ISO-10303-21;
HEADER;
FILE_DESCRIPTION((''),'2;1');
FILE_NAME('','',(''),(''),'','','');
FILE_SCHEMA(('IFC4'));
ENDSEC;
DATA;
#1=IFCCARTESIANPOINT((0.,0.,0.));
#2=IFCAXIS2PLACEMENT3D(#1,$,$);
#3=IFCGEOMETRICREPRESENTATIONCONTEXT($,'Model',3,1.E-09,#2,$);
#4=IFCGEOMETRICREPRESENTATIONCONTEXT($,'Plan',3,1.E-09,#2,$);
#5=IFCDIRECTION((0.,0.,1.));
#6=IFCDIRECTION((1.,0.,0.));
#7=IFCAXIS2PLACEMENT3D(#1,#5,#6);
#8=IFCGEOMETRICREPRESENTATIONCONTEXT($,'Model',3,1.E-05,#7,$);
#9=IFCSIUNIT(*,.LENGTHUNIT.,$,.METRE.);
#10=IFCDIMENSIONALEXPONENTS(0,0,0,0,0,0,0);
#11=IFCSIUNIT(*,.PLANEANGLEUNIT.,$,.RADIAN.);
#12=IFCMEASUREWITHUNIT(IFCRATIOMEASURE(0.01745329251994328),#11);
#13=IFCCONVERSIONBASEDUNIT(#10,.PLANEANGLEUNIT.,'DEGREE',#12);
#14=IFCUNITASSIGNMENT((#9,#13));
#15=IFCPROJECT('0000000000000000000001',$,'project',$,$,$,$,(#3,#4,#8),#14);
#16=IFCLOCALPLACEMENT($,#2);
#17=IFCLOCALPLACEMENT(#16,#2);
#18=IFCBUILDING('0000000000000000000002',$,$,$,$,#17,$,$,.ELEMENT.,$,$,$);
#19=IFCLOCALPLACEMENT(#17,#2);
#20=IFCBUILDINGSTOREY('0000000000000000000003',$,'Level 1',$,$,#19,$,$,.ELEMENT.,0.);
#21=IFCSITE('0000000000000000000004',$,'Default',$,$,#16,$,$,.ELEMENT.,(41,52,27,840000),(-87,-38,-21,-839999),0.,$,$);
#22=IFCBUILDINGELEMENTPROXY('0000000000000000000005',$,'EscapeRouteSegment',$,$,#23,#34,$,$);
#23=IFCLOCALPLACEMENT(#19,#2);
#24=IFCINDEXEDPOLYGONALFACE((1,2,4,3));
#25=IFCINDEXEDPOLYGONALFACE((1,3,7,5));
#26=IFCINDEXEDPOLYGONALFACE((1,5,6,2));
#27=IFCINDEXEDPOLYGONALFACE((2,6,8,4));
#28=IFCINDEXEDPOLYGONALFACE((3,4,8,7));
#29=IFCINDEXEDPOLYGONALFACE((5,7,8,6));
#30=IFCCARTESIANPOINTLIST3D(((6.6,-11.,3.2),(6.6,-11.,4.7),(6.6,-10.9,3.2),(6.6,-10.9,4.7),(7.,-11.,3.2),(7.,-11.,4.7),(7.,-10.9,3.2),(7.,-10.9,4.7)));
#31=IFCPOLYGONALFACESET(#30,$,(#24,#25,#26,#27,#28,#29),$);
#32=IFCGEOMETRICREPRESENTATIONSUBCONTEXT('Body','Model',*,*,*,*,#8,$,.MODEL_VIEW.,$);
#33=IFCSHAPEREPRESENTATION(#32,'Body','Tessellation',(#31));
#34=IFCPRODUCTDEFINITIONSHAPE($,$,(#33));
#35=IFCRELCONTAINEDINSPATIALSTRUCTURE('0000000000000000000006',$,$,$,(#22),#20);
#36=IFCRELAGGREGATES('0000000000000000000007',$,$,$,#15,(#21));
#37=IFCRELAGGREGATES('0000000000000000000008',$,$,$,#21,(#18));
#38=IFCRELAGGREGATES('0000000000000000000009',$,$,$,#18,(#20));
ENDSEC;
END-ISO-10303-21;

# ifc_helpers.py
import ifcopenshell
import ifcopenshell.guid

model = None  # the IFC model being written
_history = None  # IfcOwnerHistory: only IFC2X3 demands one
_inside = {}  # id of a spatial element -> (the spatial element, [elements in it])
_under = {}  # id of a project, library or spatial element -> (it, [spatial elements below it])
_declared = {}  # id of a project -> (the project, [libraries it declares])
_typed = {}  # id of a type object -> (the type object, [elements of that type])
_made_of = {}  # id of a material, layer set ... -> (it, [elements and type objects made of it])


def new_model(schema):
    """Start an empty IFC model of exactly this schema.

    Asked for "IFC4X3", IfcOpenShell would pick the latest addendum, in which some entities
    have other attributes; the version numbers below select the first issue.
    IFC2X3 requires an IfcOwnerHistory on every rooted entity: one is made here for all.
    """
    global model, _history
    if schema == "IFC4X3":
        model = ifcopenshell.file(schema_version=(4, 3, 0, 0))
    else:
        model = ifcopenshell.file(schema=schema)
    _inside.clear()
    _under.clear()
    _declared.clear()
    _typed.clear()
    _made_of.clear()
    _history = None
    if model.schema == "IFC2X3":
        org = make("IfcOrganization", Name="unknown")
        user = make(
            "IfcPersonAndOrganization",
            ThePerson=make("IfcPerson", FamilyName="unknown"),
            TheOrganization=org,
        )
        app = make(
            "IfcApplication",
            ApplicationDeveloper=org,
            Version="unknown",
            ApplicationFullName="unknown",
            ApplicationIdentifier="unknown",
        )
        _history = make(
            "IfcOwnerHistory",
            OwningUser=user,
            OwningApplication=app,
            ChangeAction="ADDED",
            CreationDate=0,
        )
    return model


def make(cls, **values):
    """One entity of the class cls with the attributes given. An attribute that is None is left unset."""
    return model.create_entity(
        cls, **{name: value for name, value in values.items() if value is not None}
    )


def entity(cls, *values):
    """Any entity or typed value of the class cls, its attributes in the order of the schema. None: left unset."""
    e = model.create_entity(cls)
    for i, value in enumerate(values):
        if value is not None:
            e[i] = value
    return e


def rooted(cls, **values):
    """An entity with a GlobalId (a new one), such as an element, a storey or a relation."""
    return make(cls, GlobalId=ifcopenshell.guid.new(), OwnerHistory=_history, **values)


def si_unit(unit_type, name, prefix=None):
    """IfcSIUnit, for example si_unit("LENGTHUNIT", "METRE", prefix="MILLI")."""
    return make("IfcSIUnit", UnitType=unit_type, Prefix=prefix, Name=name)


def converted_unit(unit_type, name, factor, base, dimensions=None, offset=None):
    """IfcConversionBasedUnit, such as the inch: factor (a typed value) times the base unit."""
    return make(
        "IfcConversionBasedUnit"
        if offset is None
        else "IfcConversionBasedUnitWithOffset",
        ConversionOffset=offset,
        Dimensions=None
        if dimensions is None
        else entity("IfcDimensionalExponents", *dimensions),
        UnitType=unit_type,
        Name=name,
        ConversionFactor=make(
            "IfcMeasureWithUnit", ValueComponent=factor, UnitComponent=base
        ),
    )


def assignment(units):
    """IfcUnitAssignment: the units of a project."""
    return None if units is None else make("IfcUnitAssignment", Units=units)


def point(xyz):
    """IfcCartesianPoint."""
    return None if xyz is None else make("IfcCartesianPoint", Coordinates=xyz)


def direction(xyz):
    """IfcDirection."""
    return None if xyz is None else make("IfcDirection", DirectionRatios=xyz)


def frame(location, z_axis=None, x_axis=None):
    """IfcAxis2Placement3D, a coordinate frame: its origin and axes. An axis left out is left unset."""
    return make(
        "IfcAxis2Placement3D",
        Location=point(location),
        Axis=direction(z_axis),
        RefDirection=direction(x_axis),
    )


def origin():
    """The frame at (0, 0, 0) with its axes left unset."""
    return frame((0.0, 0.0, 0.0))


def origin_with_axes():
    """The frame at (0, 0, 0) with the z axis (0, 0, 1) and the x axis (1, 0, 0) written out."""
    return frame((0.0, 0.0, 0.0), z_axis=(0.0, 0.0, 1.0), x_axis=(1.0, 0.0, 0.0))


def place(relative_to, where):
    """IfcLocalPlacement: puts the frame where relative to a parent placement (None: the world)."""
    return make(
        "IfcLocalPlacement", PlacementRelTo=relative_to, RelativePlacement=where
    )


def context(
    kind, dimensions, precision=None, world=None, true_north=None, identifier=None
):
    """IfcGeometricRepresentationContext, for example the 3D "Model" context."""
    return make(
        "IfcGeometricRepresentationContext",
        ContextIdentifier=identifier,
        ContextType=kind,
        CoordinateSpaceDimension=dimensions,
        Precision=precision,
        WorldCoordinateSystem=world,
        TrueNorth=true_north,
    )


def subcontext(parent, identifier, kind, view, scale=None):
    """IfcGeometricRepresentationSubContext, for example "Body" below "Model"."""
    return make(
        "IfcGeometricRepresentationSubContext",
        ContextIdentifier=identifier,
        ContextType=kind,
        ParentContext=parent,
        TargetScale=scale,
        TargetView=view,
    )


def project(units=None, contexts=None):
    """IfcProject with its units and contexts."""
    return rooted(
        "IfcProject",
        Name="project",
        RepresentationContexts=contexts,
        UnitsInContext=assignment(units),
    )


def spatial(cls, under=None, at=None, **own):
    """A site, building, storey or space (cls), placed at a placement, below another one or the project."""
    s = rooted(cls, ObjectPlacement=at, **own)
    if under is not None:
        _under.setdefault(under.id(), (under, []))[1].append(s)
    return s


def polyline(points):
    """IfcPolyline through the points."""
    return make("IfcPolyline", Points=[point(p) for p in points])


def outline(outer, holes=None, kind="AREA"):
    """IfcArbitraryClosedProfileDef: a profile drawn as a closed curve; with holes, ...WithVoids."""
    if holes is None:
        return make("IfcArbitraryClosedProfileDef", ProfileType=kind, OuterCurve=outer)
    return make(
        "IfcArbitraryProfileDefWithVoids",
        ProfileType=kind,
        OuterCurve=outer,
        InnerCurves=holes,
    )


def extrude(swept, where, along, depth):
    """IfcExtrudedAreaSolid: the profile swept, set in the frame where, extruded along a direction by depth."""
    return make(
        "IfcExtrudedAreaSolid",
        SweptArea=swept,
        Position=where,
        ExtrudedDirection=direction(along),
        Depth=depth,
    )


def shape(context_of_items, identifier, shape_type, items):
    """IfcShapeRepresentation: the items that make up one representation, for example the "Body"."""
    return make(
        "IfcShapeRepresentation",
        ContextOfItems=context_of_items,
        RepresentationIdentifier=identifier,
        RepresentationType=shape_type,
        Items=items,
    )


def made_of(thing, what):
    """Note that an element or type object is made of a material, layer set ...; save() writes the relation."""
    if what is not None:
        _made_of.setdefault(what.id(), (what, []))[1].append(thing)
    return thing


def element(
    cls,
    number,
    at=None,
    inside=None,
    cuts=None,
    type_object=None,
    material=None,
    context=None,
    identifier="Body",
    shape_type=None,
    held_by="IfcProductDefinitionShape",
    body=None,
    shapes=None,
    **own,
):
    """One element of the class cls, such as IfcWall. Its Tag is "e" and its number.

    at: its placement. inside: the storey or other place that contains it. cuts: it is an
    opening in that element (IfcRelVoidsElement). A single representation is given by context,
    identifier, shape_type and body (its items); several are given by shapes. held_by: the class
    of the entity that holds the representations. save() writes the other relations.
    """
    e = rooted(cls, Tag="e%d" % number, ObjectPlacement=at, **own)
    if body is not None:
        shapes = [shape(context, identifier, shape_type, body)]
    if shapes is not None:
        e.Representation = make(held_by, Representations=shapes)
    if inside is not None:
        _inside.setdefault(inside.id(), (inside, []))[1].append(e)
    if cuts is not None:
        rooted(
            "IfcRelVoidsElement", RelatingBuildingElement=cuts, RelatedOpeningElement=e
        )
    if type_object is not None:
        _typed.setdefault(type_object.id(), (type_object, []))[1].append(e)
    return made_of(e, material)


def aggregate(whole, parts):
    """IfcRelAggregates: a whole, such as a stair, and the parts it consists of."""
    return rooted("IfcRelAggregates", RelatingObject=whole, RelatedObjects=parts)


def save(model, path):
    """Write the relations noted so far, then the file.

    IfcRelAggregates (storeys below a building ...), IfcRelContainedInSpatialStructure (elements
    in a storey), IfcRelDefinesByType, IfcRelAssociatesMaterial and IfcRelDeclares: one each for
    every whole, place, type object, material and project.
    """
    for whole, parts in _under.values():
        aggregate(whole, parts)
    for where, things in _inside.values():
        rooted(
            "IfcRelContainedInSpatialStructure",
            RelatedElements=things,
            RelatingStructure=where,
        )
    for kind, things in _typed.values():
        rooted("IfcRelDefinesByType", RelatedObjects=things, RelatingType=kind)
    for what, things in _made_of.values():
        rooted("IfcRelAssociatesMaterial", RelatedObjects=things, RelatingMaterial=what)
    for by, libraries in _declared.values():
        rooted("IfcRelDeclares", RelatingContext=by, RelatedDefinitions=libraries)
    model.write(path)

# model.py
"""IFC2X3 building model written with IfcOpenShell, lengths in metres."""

from ifc_helpers import new_model, entity, si_unit, converted_unit, frame, origin, origin_with_axes, place, context, subcontext, project, spatial, polyline, outline, extrude, element, save


model = new_model("IFC2X3")

# Units and contexts
model_context_1 = context("Model", 3, precision=1e-09, world=origin())
plan_context = context("Plan", 3, precision=1e-09, world=origin())
model_context_2 = context("Model", 3, precision=1e-05, world=origin_with_axes())
body_context = subcontext(model_context_2, "Body", "Model", "MODEL_VIEW")
ifc_project = project(units=[si_unit("LENGTHUNIT", "METRE"), converted_unit("PLANEANGLEUNIT", "DEGREE", entity("IfcRatioMeasure", 0.01745329251994328), si_unit("PLANEANGLEUNIT", "RADIAN"), dimensions=[0, 0, 0, 0, 0, 0, 0])], contexts=[model_context_1, plan_context, model_context_2])

# Site, building, storey
site_placement = place(None, origin())
site = spatial("IfcSite", under=ifc_project, at=site_placement, Name="Default", CompositionType="ELEMENT", RefLatitude=(41, 52, 27, 840000), RefLongitude=(-87, -38, -21, -839999), RefElevation=0.0)
building_placement = place(site_placement, origin())
building = spatial("IfcBuilding", under=site, at=building_placement, CompositionType="ELEMENT")
storey_placement = place(building_placement, origin())
storey = spatial("IfcBuildingStorey", under=building, at=storey_placement, Name="Level 1", CompositionType="ELEMENT", Elevation=0.0)

# Building element proxy
for number, where, z_axis, x_axis, name in (
    (1, (6.8, -11.0, 3.2), (0.0, 0.0, 1.0), (0.0, 1.0, 0.0), "EscapeRouteSegment"),
):
    element("IfcBuildingElementProxy", number, at=place(storey_placement, frame(where, z_axis=z_axis, x_axis=x_axis)), inside=storey, Name=name, context=body_context, shape_type="SweptSolid", body=[
        extrude(outline(polyline([(0.0, -0.2), (0.0, 0.2), (0.1, 0.2), (0.1, -0.2), (0.0, -0.2)])), origin_with_axes(), (0.0, 0.0, 1.0), 1.5),
    ])

save(model, "model.ifc")
